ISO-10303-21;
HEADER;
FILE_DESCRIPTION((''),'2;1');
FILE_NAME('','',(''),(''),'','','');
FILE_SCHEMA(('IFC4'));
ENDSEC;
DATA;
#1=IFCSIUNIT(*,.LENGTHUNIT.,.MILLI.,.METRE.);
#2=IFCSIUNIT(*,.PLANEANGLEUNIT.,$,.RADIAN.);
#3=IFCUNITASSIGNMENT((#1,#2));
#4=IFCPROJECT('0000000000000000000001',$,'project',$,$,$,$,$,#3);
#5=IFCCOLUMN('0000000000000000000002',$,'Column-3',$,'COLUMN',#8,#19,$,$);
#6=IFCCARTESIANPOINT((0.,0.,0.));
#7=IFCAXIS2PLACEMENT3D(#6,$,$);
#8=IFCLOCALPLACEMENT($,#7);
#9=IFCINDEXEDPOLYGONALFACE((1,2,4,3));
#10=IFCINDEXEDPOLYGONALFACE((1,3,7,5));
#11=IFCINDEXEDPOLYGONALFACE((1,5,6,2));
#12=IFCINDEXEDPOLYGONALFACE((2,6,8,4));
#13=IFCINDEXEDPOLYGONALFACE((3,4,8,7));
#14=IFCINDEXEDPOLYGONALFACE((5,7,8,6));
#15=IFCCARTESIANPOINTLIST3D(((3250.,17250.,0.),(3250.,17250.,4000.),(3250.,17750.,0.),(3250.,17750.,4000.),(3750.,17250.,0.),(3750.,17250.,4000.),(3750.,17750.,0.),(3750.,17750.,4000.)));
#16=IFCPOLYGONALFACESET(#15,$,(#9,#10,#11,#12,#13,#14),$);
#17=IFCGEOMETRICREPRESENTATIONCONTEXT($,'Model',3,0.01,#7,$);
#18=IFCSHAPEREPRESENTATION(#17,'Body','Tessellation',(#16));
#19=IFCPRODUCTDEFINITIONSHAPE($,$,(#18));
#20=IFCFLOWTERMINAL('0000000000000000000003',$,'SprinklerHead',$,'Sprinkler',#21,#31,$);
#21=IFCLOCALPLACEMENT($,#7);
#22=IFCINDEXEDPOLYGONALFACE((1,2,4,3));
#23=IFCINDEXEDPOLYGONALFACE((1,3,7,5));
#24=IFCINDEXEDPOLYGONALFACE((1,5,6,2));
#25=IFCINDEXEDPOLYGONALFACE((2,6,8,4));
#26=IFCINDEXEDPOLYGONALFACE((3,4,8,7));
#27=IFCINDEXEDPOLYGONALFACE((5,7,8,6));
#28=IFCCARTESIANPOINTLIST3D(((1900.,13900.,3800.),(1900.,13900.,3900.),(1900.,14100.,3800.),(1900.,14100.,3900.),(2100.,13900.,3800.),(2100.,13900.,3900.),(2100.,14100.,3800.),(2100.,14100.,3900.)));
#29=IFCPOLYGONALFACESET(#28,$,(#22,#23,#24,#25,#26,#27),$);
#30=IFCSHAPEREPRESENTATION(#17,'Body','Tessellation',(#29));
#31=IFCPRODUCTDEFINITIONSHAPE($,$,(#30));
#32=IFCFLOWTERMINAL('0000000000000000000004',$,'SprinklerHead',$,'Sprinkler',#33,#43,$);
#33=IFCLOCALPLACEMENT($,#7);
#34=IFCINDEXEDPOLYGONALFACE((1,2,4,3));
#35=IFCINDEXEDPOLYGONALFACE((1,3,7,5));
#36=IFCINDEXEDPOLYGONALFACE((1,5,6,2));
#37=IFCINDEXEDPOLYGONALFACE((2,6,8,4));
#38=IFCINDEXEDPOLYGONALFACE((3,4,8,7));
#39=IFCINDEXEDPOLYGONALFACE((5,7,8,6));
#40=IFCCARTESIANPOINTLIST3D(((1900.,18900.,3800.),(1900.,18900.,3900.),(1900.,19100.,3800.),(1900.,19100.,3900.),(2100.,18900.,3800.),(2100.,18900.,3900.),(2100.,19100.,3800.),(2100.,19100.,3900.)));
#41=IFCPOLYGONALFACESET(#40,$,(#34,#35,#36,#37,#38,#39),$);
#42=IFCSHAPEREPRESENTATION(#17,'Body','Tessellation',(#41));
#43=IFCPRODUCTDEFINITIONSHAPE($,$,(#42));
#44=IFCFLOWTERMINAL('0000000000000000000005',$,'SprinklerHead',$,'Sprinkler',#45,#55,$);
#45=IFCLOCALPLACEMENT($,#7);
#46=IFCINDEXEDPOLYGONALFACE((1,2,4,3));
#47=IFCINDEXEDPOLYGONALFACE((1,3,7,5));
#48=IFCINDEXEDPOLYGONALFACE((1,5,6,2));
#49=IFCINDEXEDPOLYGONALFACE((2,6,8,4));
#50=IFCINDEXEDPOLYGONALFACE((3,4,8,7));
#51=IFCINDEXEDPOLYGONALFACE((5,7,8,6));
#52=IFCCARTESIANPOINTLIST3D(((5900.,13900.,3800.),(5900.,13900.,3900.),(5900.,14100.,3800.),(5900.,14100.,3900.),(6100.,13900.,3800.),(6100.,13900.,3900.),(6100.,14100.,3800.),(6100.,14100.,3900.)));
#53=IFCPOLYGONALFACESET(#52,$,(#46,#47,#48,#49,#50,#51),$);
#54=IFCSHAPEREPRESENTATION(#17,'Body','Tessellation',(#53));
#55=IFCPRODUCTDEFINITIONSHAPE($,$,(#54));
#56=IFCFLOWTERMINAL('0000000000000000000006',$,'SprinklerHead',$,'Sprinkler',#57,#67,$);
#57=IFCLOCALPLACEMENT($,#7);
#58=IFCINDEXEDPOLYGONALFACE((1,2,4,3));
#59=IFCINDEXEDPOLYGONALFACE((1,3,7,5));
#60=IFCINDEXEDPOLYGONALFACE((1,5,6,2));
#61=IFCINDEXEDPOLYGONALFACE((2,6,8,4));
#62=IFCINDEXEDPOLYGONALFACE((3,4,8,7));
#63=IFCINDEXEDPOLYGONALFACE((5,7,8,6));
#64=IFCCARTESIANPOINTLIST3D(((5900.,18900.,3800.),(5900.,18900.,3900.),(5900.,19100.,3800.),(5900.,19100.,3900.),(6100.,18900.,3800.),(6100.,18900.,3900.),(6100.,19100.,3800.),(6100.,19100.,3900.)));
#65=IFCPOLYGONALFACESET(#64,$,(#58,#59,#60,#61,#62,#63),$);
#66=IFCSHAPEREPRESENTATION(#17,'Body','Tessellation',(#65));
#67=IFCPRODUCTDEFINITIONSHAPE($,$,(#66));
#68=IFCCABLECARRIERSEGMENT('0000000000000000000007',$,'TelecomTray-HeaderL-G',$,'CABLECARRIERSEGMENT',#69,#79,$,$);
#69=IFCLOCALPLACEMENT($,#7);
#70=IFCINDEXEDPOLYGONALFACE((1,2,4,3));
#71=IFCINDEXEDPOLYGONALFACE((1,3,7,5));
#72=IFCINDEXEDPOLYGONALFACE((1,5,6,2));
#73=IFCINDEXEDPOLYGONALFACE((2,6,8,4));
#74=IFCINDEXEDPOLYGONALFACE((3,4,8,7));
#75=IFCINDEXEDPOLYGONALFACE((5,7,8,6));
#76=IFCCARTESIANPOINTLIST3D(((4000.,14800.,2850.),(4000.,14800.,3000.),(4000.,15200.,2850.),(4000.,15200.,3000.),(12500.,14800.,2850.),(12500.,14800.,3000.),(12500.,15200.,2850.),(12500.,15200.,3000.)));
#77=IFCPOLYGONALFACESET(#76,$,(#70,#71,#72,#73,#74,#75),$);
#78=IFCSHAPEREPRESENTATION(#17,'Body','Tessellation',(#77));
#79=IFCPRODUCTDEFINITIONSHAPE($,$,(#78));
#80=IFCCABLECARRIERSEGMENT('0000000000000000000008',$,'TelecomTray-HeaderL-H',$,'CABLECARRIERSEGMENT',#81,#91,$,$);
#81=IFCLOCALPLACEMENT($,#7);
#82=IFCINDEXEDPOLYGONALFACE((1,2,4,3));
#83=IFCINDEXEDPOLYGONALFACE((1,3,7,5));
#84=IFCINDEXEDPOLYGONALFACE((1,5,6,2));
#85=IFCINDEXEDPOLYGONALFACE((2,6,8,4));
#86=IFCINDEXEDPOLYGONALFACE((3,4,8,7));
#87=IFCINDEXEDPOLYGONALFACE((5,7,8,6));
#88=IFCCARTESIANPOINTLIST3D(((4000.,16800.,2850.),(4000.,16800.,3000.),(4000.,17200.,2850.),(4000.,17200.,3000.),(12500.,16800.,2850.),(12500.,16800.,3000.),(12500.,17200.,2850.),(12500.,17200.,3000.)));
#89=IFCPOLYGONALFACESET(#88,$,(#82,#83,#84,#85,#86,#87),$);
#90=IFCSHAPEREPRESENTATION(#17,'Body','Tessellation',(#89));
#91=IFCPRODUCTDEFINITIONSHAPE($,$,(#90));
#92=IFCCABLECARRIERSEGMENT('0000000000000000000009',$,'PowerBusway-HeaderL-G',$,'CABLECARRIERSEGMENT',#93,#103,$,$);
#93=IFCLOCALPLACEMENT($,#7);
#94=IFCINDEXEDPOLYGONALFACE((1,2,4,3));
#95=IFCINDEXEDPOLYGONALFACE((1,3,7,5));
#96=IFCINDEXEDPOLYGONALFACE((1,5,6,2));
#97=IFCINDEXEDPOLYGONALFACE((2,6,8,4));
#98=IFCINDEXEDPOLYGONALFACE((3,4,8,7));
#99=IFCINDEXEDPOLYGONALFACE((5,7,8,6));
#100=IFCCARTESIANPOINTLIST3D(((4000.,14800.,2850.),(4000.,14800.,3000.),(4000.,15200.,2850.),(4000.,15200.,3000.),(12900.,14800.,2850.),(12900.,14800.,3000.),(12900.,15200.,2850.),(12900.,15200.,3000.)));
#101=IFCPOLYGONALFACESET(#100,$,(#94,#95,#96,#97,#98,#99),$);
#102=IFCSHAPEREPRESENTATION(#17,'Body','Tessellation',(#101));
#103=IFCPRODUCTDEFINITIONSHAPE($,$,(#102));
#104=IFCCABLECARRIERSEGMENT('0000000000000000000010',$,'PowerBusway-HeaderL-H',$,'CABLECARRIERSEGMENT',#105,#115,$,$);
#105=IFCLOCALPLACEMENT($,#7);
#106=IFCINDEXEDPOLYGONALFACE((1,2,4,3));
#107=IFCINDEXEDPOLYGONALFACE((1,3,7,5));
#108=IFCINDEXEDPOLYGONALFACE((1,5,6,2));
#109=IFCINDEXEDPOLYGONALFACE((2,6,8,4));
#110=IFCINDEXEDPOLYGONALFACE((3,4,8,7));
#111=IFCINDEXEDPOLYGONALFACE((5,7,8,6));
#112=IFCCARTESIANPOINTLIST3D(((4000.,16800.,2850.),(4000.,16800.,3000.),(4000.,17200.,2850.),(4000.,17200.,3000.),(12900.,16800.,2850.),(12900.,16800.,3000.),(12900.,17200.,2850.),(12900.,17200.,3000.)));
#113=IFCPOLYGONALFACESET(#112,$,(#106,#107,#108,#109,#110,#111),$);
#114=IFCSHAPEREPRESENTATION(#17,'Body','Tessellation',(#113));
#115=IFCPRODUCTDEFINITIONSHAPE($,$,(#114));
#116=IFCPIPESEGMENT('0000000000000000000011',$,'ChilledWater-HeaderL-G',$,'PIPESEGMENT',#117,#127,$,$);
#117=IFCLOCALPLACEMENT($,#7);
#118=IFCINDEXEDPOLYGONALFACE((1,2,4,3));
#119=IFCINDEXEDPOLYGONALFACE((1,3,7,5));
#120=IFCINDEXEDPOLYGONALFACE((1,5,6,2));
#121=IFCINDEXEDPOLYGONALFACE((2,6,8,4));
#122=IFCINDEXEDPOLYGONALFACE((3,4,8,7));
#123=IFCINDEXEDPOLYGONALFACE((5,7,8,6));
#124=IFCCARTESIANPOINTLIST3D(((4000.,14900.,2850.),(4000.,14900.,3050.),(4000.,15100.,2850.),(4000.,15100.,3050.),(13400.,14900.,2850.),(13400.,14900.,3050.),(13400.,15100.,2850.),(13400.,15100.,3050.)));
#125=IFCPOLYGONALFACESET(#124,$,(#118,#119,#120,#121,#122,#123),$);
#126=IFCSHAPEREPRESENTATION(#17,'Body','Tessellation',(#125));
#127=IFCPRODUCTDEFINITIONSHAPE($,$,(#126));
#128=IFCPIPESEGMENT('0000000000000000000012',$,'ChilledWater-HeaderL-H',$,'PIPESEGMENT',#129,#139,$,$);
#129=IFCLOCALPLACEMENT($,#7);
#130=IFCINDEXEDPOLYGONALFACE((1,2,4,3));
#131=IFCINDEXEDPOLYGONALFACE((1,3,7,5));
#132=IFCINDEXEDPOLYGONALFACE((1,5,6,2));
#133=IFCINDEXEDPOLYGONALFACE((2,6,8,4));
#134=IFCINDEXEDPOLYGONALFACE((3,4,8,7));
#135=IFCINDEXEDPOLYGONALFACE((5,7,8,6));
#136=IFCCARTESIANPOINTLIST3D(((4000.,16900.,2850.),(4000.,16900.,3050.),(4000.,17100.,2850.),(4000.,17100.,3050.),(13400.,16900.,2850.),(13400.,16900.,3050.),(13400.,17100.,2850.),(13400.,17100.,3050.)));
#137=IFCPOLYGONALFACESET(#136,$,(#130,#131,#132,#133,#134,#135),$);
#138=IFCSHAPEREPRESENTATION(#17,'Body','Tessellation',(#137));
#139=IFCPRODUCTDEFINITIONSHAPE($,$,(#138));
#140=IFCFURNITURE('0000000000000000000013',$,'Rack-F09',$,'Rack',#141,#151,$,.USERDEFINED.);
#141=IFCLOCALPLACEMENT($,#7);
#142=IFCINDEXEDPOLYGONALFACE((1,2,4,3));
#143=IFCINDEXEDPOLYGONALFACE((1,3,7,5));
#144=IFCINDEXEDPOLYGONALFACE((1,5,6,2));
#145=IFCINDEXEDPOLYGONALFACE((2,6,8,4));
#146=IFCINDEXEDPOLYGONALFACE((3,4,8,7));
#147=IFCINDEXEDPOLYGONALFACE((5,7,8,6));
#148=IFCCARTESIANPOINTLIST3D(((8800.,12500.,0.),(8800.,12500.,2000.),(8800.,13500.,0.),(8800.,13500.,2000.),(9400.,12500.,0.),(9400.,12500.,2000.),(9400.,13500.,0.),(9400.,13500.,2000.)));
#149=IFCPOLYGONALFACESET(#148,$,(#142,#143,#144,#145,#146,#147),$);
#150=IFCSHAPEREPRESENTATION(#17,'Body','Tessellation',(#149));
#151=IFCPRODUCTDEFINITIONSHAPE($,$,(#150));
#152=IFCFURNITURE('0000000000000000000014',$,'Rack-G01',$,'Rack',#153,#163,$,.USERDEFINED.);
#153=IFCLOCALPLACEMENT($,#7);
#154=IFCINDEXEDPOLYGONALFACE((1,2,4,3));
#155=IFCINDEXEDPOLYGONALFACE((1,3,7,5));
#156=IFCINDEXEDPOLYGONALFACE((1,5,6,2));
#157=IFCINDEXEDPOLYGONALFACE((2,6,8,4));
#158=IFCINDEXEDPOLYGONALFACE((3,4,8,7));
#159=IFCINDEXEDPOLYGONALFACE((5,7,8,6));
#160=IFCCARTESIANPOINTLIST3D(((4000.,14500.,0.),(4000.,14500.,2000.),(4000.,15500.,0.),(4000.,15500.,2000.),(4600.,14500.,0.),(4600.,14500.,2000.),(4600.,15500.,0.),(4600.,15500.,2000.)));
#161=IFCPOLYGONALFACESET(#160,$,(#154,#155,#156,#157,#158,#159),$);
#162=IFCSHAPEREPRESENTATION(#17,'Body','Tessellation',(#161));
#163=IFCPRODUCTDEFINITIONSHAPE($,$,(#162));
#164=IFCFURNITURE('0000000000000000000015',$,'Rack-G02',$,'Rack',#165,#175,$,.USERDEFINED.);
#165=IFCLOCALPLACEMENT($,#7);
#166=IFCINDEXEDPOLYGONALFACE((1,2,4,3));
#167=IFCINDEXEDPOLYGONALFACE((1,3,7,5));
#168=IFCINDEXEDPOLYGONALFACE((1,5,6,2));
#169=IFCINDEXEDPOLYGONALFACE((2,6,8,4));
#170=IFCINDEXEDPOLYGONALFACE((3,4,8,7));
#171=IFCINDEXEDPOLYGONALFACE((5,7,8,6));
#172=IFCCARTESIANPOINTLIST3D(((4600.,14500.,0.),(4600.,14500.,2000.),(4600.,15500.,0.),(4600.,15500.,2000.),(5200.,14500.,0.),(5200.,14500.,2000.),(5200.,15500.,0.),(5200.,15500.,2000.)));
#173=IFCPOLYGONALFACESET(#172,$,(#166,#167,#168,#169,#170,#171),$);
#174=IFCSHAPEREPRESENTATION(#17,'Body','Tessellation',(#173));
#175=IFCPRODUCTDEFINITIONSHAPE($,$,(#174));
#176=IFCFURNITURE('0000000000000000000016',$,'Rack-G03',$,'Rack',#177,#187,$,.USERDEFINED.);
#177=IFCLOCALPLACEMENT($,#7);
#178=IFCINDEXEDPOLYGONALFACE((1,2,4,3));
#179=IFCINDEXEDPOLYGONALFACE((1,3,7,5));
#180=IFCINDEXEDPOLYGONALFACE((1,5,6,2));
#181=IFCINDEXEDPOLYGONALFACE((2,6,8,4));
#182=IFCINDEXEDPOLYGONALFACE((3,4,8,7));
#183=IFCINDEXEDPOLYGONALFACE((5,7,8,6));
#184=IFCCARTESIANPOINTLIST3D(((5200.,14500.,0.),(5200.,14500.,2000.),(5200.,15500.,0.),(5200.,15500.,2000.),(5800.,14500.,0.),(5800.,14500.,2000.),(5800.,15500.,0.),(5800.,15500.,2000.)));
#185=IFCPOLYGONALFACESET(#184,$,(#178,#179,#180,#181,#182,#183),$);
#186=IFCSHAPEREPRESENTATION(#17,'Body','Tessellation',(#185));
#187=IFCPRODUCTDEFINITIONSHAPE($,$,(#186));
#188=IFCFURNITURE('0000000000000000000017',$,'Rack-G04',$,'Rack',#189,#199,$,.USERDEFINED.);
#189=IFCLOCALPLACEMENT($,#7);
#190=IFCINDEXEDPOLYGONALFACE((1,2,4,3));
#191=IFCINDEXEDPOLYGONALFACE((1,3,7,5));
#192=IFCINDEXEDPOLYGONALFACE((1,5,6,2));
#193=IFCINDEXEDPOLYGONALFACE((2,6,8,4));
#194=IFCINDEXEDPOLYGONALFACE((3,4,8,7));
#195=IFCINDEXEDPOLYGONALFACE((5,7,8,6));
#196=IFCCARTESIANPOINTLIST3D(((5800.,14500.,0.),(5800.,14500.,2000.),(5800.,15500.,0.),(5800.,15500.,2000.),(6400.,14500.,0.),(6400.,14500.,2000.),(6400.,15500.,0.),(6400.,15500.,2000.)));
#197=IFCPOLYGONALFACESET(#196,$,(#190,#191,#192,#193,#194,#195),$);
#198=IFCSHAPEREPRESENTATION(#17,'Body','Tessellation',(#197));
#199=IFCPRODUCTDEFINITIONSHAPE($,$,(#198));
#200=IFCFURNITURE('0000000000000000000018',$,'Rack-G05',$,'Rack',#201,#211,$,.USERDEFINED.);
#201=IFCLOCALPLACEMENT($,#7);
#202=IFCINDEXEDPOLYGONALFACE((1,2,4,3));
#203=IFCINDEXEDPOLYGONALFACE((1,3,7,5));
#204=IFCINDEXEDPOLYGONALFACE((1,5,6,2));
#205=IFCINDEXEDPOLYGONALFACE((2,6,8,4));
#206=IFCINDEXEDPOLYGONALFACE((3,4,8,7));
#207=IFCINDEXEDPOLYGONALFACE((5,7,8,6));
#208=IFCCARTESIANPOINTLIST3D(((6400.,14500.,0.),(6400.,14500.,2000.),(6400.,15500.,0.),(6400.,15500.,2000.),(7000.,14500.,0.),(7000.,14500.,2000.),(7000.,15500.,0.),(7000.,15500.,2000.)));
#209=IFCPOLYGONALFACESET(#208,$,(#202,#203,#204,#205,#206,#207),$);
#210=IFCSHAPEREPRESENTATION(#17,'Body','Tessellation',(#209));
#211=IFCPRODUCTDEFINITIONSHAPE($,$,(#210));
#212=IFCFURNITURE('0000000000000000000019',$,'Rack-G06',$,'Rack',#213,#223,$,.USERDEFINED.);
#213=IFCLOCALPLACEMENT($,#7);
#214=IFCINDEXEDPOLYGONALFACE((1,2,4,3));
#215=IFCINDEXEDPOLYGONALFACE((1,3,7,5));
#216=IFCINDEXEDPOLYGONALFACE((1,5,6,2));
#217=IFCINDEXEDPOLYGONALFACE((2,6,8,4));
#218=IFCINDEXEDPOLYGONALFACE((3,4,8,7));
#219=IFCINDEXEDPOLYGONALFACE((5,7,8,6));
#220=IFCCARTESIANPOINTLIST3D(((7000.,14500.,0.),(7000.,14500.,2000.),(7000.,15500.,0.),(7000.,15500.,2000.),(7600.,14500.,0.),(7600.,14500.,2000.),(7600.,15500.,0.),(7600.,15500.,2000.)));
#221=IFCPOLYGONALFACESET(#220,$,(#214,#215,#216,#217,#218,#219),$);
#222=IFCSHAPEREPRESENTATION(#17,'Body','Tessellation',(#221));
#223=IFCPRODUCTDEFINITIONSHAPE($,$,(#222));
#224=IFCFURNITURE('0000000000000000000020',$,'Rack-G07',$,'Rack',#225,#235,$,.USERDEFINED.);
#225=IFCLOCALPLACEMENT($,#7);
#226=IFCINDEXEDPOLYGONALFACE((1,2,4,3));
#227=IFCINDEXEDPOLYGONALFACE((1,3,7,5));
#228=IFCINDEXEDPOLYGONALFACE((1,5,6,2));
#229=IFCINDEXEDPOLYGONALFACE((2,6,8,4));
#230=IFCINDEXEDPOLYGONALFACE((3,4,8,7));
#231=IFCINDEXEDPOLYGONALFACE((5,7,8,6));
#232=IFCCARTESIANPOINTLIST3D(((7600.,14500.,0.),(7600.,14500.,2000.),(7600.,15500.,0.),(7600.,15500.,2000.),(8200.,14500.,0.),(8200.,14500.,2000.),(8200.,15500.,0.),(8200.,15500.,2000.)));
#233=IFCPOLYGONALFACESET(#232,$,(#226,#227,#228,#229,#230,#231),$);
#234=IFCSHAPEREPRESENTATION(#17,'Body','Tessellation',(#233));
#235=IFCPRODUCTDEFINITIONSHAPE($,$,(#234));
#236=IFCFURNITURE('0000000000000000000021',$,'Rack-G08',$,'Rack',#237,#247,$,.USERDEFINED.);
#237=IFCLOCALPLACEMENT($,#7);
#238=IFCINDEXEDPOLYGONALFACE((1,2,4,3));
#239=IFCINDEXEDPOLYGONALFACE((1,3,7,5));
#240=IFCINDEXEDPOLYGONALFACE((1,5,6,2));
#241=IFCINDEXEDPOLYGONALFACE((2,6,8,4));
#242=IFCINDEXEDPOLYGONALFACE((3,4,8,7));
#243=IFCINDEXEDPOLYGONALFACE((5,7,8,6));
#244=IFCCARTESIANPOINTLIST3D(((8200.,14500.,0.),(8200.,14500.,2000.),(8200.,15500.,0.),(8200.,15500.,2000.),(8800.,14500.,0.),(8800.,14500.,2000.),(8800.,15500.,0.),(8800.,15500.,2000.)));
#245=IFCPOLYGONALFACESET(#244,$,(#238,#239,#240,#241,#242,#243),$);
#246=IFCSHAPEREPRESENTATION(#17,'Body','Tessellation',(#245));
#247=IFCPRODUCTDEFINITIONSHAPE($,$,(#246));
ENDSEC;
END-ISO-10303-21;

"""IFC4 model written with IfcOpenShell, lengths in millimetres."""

from ifc_helpers import new_model, si_unit, frame, origin, place, context, project, polyline, outline, extrude, element, save


model = new_model("IFC4")

# Units and contexts
model_context = context("Model", 3, precision=0.01, world=origin())
ifc_project = project(units=[si_unit("LENGTHUNIT", "METRE", prefix="MILLI"), si_unit("PLANEANGLEUNIT", "RADIAN")])

# Column
column_placement = place(None, frame((3500.0, 17500.0, 0.0)))
element("IfcColumn", 1, at=column_placement, Name="Column-3", ObjectType="COLUMN", context=model_context, shape_type="SweptSolid", body=[
    extrude(outline(polyline([(-250.0, -250.0), (250.0, -250.0), (250.0, 250.0), (-250.0, 250.0), (-250.0, -250.0)])), origin(), (0.0, 0.0, 1.0), 4000.0),
])

# Flow terminals
for number, where, name in (
    (2, (2000.0, 14000.0, 3800.0), "SprinklerHead"),
    (3, (2000.0, 19000.0, 3800.0), "SprinklerHead"),
    (4, (6000.0, 14000.0, 3800.0), "SprinklerHead"),
    (5, (6000.0, 19000.0, 3800.0), "SprinklerHead"),
):
    element("IfcFlowTerminal", number, at=place(None, frame(where)), Name=name, ObjectType="Sprinkler", context=model_context, shape_type="SweptSolid", body=[
        extrude(outline(polyline([(-100.0, -100.0), (100.0, -100.0), (100.0, 100.0), (-100.0, 100.0), (-100.0, -100.0)])), origin(), (0.0, 0.0, 1.0), 100.0),
    ])

# Cable carrier segments
for number, where, name in (
    (6, (8250.0, 15000.0, 2850.0), "TelecomTray-HeaderL-G"),
    (7, (8250.0, 17000.0, 2850.0), "TelecomTray-HeaderL-H"),
):
    element("IfcCableCarrierSegment", number, at=place(None, frame(where)), Name=name, ObjectType="CABLECARRIERSEGMENT", context=model_context, shape_type="SweptSolid", body=[
        extrude(outline(polyline([(-4250.0, -200.0), (4250.0, -200.0), (4250.0, 200.0), (-4250.0, 200.0), (-4250.0, -200.0)])), origin(), (0.0, 0.0, 1.0), 150.0),
    ])
for number, where, name in (
    (8, (8450.0, 15000.0, 2850.0), "PowerBusway-HeaderL-G"),
    (9, (8450.0, 17000.0, 2850.0), "PowerBusway-HeaderL-H"),
):
    element("IfcCableCarrierSegment", number, at=place(None, frame(where)), Name=name, ObjectType="CABLECARRIERSEGMENT", context=model_context, shape_type="SweptSolid", body=[
        extrude(outline(polyline([(-4450.0, -200.0), (4450.0, -200.0), (4450.0, 200.0), (-4450.0, 200.0), (-4450.0, -200.0)])), origin(), (0.0, 0.0, 1.0), 150.0),
    ])

# Pipe segments
for number, where, name in (
    (10, (8700.0, 15000.0, 2850.0), "ChilledWater-HeaderL-G"),
    (11, (8700.0, 17000.0, 2850.0), "ChilledWater-HeaderL-H"),
):
    element("IfcPipeSegment", number, at=place(None, frame(where)), Name=name, ObjectType="PIPESEGMENT", context=model_context, shape_type="SweptSolid", body=[
        extrude(outline(polyline([(-4700.0, -100.0), (4700.0, -100.0), (4700.0, 100.0), (-4700.0, 100.0), (-4700.0, -100.0)])), origin(), (0.0, 0.0, 1.0), 200.0),
    ])

# Furniture
for number, where, name in (
    (12, (9100.0, 13000.0, 0.0), "Rack-F09"),
    (13, (4300.0, 15000.0, 0.0), "Rack-G01"),
    (14, (4900.0, 15000.0, 0.0), "Rack-G02"),
    (15, (5500.0, 15000.0, 0.0), "Rack-G03"),
    (16, (6100.0, 15000.0, 0.0), "Rack-G04"),
    (17, (6700.0, 15000.0, 0.0), "Rack-G05"),
    (18, (7300.0, 15000.0, 0.0), "Rack-G06"),
    (19, (7900.0, 15000.0, 0.0), "Rack-G07"),
    (20, (8500.0, 15000.0, 0.0), "Rack-G08"),
):
    element("IfcFurniture", number, at=place(None, frame(where)), Name=name, ObjectType="Rack", PredefinedType="USERDEFINED", context=model_context, shape_type="SweptSolid", body=[
        extrude(outline(polyline([(-300.0, -500.0), (300.0, -500.0), (300.0, 500.0), (-300.0, 500.0), (-300.0, -500.0)])), origin(), (0.0, 0.0, 1.0), 2000.0),
    ])

save(model, "model.ifc")
